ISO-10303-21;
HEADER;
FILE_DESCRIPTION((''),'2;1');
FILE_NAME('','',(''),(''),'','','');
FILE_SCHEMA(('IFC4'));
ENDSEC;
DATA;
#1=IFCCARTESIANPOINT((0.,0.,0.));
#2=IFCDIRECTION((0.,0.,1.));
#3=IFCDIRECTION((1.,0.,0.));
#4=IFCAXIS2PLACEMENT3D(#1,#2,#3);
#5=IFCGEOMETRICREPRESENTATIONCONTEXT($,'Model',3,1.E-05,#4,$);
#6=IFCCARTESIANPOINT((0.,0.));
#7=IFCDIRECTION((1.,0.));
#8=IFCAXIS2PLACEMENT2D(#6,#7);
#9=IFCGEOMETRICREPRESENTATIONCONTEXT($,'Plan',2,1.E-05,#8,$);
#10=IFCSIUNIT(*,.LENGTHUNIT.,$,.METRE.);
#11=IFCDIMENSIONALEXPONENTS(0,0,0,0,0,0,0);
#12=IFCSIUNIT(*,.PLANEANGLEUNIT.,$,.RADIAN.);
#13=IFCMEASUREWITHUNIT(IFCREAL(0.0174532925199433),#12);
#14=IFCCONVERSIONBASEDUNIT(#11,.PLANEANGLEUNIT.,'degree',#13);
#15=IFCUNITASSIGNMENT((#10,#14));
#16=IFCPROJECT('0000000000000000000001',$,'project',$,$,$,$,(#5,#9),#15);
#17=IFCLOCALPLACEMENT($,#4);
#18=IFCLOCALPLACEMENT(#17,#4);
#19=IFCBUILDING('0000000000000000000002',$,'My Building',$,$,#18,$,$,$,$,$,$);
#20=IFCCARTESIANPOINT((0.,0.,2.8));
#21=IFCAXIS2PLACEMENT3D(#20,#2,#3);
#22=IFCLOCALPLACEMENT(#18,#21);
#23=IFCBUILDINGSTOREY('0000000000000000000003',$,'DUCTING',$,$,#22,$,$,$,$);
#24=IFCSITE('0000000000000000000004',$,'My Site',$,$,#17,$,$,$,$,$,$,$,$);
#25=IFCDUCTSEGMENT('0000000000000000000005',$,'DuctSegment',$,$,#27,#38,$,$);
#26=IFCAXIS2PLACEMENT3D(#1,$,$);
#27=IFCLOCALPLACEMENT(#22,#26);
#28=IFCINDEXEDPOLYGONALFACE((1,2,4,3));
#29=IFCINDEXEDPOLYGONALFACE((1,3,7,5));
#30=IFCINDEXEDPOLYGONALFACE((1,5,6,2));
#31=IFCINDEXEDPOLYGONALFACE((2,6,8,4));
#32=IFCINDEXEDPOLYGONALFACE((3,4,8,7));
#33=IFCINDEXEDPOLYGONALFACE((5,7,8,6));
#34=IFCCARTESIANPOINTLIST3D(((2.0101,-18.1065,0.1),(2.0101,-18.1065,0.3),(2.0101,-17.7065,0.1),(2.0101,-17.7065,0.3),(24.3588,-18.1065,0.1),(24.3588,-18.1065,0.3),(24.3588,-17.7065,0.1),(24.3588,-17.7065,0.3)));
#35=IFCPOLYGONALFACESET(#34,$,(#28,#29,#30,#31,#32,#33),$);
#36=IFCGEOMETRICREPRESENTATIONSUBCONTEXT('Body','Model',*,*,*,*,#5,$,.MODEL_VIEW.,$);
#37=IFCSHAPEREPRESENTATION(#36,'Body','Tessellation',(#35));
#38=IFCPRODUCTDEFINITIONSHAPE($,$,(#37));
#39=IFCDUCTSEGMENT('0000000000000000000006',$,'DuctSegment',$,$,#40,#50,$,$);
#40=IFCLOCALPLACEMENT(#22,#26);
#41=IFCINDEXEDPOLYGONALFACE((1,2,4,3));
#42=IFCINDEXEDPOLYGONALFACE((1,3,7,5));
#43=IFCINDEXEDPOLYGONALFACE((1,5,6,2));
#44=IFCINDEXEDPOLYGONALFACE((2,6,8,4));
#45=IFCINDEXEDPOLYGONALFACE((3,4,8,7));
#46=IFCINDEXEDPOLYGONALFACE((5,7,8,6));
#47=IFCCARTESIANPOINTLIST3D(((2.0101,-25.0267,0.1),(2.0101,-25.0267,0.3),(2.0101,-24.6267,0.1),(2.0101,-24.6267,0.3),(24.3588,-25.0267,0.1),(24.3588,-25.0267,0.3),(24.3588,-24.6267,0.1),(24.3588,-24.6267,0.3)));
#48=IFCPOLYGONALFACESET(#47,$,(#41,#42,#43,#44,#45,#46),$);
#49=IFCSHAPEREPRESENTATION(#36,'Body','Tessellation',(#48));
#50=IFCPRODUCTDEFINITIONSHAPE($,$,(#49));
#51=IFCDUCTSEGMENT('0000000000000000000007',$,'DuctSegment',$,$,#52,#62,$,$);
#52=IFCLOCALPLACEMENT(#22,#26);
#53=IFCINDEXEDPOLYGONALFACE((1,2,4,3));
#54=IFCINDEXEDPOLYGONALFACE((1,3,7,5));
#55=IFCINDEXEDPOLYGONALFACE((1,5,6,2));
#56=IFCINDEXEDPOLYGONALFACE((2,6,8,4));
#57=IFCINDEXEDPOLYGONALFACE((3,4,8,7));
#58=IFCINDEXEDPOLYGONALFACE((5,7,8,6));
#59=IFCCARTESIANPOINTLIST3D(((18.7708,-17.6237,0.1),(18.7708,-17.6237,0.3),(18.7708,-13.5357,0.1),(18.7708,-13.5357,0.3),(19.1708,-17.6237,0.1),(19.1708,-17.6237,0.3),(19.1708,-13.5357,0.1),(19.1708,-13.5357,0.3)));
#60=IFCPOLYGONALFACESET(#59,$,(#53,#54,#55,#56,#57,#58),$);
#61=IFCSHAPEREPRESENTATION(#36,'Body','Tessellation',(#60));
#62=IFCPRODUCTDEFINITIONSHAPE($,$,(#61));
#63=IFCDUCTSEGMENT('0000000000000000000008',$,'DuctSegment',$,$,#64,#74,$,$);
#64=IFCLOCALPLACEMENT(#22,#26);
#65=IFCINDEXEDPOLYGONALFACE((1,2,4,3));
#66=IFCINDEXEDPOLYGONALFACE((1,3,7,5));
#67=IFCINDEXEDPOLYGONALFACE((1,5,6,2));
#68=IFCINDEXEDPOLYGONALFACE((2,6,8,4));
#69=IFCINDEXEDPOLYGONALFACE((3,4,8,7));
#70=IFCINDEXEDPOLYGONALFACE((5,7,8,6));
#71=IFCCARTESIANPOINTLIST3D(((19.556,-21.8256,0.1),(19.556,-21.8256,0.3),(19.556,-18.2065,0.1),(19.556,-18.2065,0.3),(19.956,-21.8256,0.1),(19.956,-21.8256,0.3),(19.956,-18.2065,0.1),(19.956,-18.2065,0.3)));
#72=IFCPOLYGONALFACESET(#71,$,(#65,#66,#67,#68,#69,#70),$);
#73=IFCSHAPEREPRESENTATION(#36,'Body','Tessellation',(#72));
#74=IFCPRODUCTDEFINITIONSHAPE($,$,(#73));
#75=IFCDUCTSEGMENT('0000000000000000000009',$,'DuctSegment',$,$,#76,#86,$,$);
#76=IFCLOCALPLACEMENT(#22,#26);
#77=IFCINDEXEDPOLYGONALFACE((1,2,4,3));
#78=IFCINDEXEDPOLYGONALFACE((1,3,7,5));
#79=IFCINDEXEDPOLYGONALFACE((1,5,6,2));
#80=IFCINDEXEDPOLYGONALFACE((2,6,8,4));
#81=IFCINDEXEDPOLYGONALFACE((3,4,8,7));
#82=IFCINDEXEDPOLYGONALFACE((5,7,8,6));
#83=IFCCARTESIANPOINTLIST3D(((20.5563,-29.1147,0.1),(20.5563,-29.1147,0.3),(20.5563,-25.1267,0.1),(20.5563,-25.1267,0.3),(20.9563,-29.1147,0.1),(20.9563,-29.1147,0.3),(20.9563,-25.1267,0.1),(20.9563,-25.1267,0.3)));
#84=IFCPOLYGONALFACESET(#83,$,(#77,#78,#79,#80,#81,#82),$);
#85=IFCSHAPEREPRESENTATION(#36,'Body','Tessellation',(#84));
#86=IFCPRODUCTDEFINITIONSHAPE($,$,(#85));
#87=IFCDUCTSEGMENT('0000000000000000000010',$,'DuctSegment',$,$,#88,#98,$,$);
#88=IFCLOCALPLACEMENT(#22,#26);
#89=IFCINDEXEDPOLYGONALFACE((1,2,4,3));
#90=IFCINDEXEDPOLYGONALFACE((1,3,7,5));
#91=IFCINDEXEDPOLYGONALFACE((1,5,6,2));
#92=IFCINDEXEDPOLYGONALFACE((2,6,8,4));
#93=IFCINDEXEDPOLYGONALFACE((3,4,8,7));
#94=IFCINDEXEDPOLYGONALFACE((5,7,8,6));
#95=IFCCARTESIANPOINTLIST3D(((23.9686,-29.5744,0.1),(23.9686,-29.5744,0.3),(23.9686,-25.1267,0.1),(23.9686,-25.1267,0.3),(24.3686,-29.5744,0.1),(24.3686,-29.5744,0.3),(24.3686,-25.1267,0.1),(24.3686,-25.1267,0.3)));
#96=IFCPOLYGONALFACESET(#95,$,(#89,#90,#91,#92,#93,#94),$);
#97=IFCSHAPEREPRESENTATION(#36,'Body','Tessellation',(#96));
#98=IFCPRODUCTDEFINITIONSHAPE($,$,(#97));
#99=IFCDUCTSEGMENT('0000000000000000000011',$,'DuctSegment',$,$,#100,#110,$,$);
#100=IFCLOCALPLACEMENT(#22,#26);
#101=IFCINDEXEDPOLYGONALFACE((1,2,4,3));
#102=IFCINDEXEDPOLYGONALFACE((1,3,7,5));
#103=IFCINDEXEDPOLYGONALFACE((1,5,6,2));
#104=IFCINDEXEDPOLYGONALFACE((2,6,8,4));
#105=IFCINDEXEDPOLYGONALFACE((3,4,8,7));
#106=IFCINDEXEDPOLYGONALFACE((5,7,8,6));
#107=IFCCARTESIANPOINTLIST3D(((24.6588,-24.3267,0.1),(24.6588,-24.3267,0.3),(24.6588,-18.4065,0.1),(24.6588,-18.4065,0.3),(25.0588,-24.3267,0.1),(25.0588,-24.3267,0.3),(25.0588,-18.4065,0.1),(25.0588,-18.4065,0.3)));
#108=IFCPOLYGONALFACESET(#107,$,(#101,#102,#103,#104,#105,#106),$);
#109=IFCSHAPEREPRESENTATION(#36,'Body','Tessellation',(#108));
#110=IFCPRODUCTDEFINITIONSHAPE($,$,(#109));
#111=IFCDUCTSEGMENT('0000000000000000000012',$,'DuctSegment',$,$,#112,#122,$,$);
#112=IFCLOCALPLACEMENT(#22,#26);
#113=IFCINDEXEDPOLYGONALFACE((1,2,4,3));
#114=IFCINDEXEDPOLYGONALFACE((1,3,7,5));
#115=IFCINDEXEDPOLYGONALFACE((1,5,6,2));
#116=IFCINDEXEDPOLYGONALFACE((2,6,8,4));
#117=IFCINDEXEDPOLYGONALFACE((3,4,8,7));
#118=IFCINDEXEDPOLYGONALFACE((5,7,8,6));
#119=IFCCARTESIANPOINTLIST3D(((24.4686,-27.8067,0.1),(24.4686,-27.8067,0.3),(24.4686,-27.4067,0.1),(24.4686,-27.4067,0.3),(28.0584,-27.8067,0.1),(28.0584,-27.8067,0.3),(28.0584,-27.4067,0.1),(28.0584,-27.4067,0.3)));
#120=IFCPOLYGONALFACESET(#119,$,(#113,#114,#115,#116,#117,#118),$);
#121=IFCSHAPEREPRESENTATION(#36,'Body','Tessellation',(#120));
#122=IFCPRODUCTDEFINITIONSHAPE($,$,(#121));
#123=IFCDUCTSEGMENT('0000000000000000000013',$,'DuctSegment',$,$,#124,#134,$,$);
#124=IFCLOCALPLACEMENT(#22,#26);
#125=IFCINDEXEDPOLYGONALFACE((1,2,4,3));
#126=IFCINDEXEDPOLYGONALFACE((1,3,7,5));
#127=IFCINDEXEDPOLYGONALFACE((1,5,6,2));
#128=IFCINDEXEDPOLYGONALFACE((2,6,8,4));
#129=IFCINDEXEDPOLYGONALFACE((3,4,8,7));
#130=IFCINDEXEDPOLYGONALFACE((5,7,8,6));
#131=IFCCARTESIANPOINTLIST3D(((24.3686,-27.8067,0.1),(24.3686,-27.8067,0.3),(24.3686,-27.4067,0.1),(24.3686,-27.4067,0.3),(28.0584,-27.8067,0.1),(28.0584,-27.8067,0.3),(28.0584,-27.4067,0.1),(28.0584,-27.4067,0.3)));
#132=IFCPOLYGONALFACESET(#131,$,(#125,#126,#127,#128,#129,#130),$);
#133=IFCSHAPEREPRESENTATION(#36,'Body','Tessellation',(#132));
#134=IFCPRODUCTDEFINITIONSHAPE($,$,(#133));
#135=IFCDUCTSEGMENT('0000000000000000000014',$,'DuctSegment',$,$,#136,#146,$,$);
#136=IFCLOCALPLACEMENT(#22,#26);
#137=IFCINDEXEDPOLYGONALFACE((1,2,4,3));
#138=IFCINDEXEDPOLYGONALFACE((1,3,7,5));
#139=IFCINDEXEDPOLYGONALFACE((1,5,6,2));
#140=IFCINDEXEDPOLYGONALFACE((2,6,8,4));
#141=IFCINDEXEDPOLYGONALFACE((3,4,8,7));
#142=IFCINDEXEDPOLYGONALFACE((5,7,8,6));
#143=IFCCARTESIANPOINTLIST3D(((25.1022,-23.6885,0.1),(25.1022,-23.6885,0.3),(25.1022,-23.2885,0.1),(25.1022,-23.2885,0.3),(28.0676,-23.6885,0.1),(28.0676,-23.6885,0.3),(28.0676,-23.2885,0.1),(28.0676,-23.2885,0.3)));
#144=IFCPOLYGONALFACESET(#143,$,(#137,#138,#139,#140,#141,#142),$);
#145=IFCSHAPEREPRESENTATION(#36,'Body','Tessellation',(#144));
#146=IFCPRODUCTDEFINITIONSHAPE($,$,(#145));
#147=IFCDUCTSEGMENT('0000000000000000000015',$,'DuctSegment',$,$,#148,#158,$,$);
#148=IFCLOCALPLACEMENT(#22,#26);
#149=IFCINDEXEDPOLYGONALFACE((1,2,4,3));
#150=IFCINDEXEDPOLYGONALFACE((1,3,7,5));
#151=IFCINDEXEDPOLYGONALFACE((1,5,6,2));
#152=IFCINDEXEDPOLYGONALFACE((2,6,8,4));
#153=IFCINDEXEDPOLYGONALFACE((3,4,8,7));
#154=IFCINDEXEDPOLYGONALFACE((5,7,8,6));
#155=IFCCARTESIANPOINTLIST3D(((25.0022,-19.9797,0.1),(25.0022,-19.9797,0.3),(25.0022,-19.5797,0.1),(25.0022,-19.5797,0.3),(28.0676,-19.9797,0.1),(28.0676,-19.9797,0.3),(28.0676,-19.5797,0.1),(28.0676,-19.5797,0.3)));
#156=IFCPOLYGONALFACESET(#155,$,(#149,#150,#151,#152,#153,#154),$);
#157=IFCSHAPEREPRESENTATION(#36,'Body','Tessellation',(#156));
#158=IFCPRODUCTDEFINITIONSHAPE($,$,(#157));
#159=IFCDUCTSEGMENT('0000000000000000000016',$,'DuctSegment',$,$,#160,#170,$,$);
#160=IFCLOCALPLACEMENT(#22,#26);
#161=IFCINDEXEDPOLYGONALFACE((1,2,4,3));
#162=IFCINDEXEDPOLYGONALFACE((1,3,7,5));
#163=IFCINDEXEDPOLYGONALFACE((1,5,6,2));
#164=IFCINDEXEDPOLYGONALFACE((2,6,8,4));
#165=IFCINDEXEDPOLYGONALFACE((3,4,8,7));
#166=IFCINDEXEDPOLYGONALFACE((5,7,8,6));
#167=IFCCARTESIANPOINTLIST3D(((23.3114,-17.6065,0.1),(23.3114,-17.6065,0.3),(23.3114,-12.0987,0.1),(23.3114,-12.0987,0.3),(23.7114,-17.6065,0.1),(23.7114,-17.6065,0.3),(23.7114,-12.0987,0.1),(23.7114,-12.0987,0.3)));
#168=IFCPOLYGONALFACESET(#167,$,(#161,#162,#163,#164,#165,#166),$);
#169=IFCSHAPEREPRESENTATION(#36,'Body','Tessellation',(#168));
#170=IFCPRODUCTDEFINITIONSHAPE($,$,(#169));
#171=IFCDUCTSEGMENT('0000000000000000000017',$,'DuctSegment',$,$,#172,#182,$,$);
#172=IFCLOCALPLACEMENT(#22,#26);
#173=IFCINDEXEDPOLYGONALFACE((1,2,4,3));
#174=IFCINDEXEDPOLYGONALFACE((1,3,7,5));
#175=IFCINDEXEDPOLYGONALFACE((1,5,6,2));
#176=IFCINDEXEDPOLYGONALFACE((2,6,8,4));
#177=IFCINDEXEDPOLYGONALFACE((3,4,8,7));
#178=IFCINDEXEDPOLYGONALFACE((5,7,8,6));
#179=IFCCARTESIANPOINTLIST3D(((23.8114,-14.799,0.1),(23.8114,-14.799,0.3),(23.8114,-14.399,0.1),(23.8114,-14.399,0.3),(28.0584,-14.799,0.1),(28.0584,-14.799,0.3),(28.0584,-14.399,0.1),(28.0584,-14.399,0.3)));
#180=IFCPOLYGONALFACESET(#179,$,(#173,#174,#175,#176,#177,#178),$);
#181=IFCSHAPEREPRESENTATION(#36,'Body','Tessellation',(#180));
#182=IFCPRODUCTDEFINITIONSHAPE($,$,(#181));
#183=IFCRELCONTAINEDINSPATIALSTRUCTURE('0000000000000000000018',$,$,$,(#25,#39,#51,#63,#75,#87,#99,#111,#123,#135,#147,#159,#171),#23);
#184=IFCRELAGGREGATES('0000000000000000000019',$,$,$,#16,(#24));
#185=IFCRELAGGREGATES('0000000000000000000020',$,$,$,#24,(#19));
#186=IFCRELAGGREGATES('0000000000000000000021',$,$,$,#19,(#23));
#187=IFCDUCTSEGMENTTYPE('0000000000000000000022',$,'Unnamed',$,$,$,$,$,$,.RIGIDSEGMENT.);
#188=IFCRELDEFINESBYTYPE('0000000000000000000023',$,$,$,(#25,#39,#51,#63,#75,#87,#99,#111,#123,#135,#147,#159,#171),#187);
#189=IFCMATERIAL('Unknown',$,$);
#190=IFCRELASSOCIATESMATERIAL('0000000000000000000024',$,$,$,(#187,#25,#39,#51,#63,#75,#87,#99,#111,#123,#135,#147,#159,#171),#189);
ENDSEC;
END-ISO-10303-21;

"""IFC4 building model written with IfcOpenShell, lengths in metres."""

from ifc_helpers import new_model, entity, si_unit, converted_unit, frame, origin_with_axes, origin_2d_with_axis, place, context, subcontext, project, spatial, rectangle, extrude, material, material_profile, profile_set, profile_usage, type_object, element, save


model = new_model("IFC4")

# Units and contexts
model_context = context("Model", 3, precision=1e-05, world=origin_with_axes())
plan_context = context("Plan", 2, precision=1e-05, world=origin_2d_with_axis())
body_context = subcontext(model_context, "Body", "Model", "MODEL_VIEW")
ifc_project = project(units=[si_unit("LENGTHUNIT", "METRE"), converted_unit("PLANEANGLEUNIT", "degree", entity("IfcReal", 0.0174532925199433), si_unit("PLANEANGLEUNIT", "RADIAN"), dimensions=[0, 0, 0, 0, 0, 0, 0])], contexts=[model_context, plan_context])

# Site, building, storey
site_placement = place(None, origin_with_axes())
site = spatial("IfcSite", under=ifc_project, at=site_placement, Name="My Site")
building_placement = place(site_placement, origin_with_axes())
building = spatial("IfcBuilding", under=site, at=building_placement, Name="My Building")
storey_placement = place(building_placement, frame((0.0, 0.0, 2.8), z_axis=(0.0, 0.0, 1.0), x_axis=(1.0, 0.0, 0.0)))
storey = spatial("IfcBuildingStorey", under=building, at=storey_placement, Name="DUCTING")

# Duct segments
ifc_material = material(Name="Unknown")
ifc_material_profile_1 = material_profile(ifc_material, rectangle(XDim=0.4, YDim=0.2))
ifc_profile_set_1 = profile_set([ifc_material_profile_1])
ifc_profile_usage_1 = profile_usage(ifc_profile_set_1, cardinal=5)
duct_segment_type = type_object("IfcDuctSegmentType", Name="Unnamed", PredefinedType="RIGIDSEGMENT", material=ifc_profile_set_1)
duct_segment_1_placement = place(storey_placement, frame((24.3588, -17.9065, 0.2), z_axis=(-1.0, 0.0, 0.0), x_axis=(0.0, -1.0, 0.0)))
element("IfcDuctSegment", 1, at=duct_segment_1_placement, inside=storey, type_object=duct_segment_type, material=ifc_profile_usage_1, Name="DuctSegment", context=body_context, shape_type="SweptSolid", body=[
    extrude(rectangle(XDim=0.4, YDim=0.2), origin_with_axes(), (0.0, 0.0, 1.0), 22.3487),
])
ifc_profile_usage_2 = profile_usage(ifc_profile_set_1, cardinal=5)
duct_segment_2_placement = place(storey_placement, frame((24.3588, -24.8267, 0.2), z_axis=(-1.0, 0.0, 0.0), x_axis=(0.0, -1.0, 0.0)))
element("IfcDuctSegment", 2, at=duct_segment_2_placement, inside=storey, type_object=duct_segment_type, material=ifc_profile_usage_2, Name="DuctSegment", context=body_context, shape_type="SweptSolid", body=[
    extrude(rectangle(XDim=0.4, YDim=0.2), origin_with_axes(), (0.0, 0.0, 1.0), 22.3487),
])
ifc_profile_usage_3 = profile_usage(ifc_profile_set_1, cardinal=5)
duct_segment_3_placement = place(storey_placement, frame((18.9708, -17.6237, 0.2), z_axis=(0.0, 1.0, 0.0), x_axis=(-1.0, 0.0, 0.0)))
element("IfcDuctSegment", 3, at=duct_segment_3_placement, inside=storey, type_object=duct_segment_type, material=ifc_profile_usage_3, Name="DuctSegment", context=body_context, shape_type="SweptSolid", body=[
    extrude(rectangle(XDim=0.4, YDim=0.2), origin_with_axes(), (0.0, 0.0, 1.0), 4.088),
])
ifc_profile_usage_4 = profile_usage(ifc_profile_set_1, cardinal=5)
duct_segment_4_placement = place(storey_placement, frame((19.756, -18.2065, 0.2), z_axis=(0.0, -1.0, 0.0), x_axis=(1.0, 0.0, 0.0)))
element("IfcDuctSegment", 4, at=duct_segment_4_placement, inside=storey, type_object=duct_segment_type, material=ifc_profile_usage_4, Name="DuctSegment", context=body_context, shape_type="SweptSolid", body=[
    extrude(rectangle(XDim=0.4, YDim=0.2), origin_with_axes(), (0.0, 0.0, 1.0), 3.6191),
])
ifc_profile_usage_5 = profile_usage(ifc_profile_set_1, cardinal=5)
duct_segment_5_placement = place(storey_placement, frame((20.7563, -25.1267, 0.2), z_axis=(0.0, -1.0, 0.0), x_axis=(1.0, 0.0, 0.0)))
element("IfcDuctSegment", 5, at=duct_segment_5_placement, inside=storey, type_object=duct_segment_type, material=ifc_profile_usage_5, Name="DuctSegment", context=body_context, shape_type="SweptSolid", body=[
    extrude(rectangle(XDim=0.4, YDim=0.2), origin_with_axes(), (0.0, 0.0, 1.0), 3.988),
])
ifc_profile_usage_6 = profile_usage(ifc_profile_set_1, cardinal=5)
duct_segment_6_placement = place(storey_placement, frame((24.1686, -25.1267, 0.2), z_axis=(0.0, -1.0, 0.0), x_axis=(1.0, 0.0, 0.0)))
element("IfcDuctSegment", 6, at=duct_segment_6_placement, inside=storey, type_object=duct_segment_type, material=ifc_profile_usage_6, Name="DuctSegment", context=body_context, shape_type="SweptSolid", body=[
    extrude(rectangle(XDim=0.4, YDim=0.2), origin_with_axes(), (0.0, 0.0, 1.0), 4.4477),
])
ifc_profile_usage_7 = profile_usage(ifc_profile_set_1, cardinal=5)
duct_segment_7_placement = place(storey_placement, frame((24.8588, -18.4065, 0.2), z_axis=(0.0, -1.0, 0.0), x_axis=(1.0, 0.0, 0.0)))
element("IfcDuctSegment", 7, at=duct_segment_7_placement, inside=storey, type_object=duct_segment_type, material=ifc_profile_usage_7, Name="DuctSegment", context=body_context, shape_type="SweptSolid", body=[
    extrude(rectangle(XDim=0.4, YDim=0.2), origin_with_axes(), (0.0, 0.0, 1.0), 5.9202),
])
ifc_profile_usage_8 = profile_usage(ifc_profile_set_1, cardinal=5)
duct_segment_8_placement = place(storey_placement, frame((24.4686, -27.6067, 0.2), z_axis=(1.0, 0.0, 0.0), x_axis=(0.0, 1.0, 0.0)))
element("IfcDuctSegment", 8, at=duct_segment_8_placement, inside=storey, type_object=duct_segment_type, material=ifc_profile_usage_8, Name="DuctSegment", context=body_context, shape_type="SweptSolid", body=[
    extrude(rectangle(XDim=0.4, YDim=0.2), origin_with_axes(), (0.0, 0.0, 1.0), 3.5897),
])
ifc_profile_usage_9 = profile_usage(ifc_profile_set_1, cardinal=5)
duct_segment_9_placement = place(storey_placement, frame((24.3686, -27.6067, 0.2), z_axis=(1.0, 0.0, 0.0), x_axis=(0.0, 1.0, 0.0)))
element("IfcDuctSegment", 9, at=duct_segment_9_placement, inside=storey, type_object=duct_segment_type, material=ifc_profile_usage_9, Name="DuctSegment", context=body_context, shape_type="SweptSolid", body=[
    extrude(rectangle(XDim=0.4, YDim=0.2), origin_with_axes(), (0.0, 0.0, 1.0), 3.6897),
])
ifc_profile_usage_10 = profile_usage(ifc_profile_set_1, cardinal=5)
duct_segment_10_placement = place(storey_placement, frame((25.1022, -23.4885, 0.2), z_axis=(1.0, -0.000001, 0.0), x_axis=(0.000001, 1.0, 0.0)))
element("IfcDuctSegment", 10, at=duct_segment_10_placement, inside=storey, type_object=duct_segment_type, material=ifc_profile_usage_10, Name="DuctSegment", context=body_context, shape_type="SweptSolid", body=[
    extrude(rectangle(XDim=0.4, YDim=0.2), origin_with_axes(), (0.0, 0.0, 1.0), 2.9654),
])
ifc_profile_usage_11 = profile_usage(ifc_profile_set_1, cardinal=5)
duct_segment_11_placement = place(storey_placement, frame((25.0022, -19.7797, 0.2), z_axis=(1.0, -0.000001, 0.0), x_axis=(0.000001, 1.0, 0.0)))
element("IfcDuctSegment", 11, at=duct_segment_11_placement, inside=storey, type_object=duct_segment_type, material=ifc_profile_usage_11, Name="DuctSegment", context=body_context, shape_type="SweptSolid", body=[
    extrude(rectangle(XDim=0.4, YDim=0.2), origin_with_axes(), (0.0, 0.0, 1.0), 3.0654),
])
ifc_profile_usage_12 = profile_usage(ifc_profile_set_1, cardinal=5)
duct_segment_12_placement = place(storey_placement, frame((23.5114, -17.6065, 0.2), z_axis=(0.0, 1.0, 0.0), x_axis=(-1.0, 0.0, 0.0)))
element("IfcDuctSegment", 12, at=duct_segment_12_placement, inside=storey, type_object=duct_segment_type, material=ifc_profile_usage_12, Name="DuctSegment", context=body_context, shape_type="SweptSolid", body=[
    extrude(rectangle(XDim=0.4, YDim=0.2), origin_with_axes(), (0.0, 0.0, 1.0), 5.5079),
])
ifc_profile_usage_13 = profile_usage(ifc_profile_set_1, cardinal=5)
duct_segment_13_placement = place(storey_placement, frame((23.8114, -14.599, 0.2), z_axis=(1.0, 0.0, 0.0), x_axis=(0.0, 1.0, 0.0)))
element("IfcDuctSegment", 13, at=duct_segment_13_placement, inside=storey, type_object=duct_segment_type, material=ifc_profile_usage_13, Name="DuctSegment", context=body_context, shape_type="SweptSolid", body=[
    extrude(rectangle(XDim=0.4, YDim=0.2), origin_with_axes(), (0.0, 0.0, 1.0), 4.247),
])

save(model, "model.ifc")
